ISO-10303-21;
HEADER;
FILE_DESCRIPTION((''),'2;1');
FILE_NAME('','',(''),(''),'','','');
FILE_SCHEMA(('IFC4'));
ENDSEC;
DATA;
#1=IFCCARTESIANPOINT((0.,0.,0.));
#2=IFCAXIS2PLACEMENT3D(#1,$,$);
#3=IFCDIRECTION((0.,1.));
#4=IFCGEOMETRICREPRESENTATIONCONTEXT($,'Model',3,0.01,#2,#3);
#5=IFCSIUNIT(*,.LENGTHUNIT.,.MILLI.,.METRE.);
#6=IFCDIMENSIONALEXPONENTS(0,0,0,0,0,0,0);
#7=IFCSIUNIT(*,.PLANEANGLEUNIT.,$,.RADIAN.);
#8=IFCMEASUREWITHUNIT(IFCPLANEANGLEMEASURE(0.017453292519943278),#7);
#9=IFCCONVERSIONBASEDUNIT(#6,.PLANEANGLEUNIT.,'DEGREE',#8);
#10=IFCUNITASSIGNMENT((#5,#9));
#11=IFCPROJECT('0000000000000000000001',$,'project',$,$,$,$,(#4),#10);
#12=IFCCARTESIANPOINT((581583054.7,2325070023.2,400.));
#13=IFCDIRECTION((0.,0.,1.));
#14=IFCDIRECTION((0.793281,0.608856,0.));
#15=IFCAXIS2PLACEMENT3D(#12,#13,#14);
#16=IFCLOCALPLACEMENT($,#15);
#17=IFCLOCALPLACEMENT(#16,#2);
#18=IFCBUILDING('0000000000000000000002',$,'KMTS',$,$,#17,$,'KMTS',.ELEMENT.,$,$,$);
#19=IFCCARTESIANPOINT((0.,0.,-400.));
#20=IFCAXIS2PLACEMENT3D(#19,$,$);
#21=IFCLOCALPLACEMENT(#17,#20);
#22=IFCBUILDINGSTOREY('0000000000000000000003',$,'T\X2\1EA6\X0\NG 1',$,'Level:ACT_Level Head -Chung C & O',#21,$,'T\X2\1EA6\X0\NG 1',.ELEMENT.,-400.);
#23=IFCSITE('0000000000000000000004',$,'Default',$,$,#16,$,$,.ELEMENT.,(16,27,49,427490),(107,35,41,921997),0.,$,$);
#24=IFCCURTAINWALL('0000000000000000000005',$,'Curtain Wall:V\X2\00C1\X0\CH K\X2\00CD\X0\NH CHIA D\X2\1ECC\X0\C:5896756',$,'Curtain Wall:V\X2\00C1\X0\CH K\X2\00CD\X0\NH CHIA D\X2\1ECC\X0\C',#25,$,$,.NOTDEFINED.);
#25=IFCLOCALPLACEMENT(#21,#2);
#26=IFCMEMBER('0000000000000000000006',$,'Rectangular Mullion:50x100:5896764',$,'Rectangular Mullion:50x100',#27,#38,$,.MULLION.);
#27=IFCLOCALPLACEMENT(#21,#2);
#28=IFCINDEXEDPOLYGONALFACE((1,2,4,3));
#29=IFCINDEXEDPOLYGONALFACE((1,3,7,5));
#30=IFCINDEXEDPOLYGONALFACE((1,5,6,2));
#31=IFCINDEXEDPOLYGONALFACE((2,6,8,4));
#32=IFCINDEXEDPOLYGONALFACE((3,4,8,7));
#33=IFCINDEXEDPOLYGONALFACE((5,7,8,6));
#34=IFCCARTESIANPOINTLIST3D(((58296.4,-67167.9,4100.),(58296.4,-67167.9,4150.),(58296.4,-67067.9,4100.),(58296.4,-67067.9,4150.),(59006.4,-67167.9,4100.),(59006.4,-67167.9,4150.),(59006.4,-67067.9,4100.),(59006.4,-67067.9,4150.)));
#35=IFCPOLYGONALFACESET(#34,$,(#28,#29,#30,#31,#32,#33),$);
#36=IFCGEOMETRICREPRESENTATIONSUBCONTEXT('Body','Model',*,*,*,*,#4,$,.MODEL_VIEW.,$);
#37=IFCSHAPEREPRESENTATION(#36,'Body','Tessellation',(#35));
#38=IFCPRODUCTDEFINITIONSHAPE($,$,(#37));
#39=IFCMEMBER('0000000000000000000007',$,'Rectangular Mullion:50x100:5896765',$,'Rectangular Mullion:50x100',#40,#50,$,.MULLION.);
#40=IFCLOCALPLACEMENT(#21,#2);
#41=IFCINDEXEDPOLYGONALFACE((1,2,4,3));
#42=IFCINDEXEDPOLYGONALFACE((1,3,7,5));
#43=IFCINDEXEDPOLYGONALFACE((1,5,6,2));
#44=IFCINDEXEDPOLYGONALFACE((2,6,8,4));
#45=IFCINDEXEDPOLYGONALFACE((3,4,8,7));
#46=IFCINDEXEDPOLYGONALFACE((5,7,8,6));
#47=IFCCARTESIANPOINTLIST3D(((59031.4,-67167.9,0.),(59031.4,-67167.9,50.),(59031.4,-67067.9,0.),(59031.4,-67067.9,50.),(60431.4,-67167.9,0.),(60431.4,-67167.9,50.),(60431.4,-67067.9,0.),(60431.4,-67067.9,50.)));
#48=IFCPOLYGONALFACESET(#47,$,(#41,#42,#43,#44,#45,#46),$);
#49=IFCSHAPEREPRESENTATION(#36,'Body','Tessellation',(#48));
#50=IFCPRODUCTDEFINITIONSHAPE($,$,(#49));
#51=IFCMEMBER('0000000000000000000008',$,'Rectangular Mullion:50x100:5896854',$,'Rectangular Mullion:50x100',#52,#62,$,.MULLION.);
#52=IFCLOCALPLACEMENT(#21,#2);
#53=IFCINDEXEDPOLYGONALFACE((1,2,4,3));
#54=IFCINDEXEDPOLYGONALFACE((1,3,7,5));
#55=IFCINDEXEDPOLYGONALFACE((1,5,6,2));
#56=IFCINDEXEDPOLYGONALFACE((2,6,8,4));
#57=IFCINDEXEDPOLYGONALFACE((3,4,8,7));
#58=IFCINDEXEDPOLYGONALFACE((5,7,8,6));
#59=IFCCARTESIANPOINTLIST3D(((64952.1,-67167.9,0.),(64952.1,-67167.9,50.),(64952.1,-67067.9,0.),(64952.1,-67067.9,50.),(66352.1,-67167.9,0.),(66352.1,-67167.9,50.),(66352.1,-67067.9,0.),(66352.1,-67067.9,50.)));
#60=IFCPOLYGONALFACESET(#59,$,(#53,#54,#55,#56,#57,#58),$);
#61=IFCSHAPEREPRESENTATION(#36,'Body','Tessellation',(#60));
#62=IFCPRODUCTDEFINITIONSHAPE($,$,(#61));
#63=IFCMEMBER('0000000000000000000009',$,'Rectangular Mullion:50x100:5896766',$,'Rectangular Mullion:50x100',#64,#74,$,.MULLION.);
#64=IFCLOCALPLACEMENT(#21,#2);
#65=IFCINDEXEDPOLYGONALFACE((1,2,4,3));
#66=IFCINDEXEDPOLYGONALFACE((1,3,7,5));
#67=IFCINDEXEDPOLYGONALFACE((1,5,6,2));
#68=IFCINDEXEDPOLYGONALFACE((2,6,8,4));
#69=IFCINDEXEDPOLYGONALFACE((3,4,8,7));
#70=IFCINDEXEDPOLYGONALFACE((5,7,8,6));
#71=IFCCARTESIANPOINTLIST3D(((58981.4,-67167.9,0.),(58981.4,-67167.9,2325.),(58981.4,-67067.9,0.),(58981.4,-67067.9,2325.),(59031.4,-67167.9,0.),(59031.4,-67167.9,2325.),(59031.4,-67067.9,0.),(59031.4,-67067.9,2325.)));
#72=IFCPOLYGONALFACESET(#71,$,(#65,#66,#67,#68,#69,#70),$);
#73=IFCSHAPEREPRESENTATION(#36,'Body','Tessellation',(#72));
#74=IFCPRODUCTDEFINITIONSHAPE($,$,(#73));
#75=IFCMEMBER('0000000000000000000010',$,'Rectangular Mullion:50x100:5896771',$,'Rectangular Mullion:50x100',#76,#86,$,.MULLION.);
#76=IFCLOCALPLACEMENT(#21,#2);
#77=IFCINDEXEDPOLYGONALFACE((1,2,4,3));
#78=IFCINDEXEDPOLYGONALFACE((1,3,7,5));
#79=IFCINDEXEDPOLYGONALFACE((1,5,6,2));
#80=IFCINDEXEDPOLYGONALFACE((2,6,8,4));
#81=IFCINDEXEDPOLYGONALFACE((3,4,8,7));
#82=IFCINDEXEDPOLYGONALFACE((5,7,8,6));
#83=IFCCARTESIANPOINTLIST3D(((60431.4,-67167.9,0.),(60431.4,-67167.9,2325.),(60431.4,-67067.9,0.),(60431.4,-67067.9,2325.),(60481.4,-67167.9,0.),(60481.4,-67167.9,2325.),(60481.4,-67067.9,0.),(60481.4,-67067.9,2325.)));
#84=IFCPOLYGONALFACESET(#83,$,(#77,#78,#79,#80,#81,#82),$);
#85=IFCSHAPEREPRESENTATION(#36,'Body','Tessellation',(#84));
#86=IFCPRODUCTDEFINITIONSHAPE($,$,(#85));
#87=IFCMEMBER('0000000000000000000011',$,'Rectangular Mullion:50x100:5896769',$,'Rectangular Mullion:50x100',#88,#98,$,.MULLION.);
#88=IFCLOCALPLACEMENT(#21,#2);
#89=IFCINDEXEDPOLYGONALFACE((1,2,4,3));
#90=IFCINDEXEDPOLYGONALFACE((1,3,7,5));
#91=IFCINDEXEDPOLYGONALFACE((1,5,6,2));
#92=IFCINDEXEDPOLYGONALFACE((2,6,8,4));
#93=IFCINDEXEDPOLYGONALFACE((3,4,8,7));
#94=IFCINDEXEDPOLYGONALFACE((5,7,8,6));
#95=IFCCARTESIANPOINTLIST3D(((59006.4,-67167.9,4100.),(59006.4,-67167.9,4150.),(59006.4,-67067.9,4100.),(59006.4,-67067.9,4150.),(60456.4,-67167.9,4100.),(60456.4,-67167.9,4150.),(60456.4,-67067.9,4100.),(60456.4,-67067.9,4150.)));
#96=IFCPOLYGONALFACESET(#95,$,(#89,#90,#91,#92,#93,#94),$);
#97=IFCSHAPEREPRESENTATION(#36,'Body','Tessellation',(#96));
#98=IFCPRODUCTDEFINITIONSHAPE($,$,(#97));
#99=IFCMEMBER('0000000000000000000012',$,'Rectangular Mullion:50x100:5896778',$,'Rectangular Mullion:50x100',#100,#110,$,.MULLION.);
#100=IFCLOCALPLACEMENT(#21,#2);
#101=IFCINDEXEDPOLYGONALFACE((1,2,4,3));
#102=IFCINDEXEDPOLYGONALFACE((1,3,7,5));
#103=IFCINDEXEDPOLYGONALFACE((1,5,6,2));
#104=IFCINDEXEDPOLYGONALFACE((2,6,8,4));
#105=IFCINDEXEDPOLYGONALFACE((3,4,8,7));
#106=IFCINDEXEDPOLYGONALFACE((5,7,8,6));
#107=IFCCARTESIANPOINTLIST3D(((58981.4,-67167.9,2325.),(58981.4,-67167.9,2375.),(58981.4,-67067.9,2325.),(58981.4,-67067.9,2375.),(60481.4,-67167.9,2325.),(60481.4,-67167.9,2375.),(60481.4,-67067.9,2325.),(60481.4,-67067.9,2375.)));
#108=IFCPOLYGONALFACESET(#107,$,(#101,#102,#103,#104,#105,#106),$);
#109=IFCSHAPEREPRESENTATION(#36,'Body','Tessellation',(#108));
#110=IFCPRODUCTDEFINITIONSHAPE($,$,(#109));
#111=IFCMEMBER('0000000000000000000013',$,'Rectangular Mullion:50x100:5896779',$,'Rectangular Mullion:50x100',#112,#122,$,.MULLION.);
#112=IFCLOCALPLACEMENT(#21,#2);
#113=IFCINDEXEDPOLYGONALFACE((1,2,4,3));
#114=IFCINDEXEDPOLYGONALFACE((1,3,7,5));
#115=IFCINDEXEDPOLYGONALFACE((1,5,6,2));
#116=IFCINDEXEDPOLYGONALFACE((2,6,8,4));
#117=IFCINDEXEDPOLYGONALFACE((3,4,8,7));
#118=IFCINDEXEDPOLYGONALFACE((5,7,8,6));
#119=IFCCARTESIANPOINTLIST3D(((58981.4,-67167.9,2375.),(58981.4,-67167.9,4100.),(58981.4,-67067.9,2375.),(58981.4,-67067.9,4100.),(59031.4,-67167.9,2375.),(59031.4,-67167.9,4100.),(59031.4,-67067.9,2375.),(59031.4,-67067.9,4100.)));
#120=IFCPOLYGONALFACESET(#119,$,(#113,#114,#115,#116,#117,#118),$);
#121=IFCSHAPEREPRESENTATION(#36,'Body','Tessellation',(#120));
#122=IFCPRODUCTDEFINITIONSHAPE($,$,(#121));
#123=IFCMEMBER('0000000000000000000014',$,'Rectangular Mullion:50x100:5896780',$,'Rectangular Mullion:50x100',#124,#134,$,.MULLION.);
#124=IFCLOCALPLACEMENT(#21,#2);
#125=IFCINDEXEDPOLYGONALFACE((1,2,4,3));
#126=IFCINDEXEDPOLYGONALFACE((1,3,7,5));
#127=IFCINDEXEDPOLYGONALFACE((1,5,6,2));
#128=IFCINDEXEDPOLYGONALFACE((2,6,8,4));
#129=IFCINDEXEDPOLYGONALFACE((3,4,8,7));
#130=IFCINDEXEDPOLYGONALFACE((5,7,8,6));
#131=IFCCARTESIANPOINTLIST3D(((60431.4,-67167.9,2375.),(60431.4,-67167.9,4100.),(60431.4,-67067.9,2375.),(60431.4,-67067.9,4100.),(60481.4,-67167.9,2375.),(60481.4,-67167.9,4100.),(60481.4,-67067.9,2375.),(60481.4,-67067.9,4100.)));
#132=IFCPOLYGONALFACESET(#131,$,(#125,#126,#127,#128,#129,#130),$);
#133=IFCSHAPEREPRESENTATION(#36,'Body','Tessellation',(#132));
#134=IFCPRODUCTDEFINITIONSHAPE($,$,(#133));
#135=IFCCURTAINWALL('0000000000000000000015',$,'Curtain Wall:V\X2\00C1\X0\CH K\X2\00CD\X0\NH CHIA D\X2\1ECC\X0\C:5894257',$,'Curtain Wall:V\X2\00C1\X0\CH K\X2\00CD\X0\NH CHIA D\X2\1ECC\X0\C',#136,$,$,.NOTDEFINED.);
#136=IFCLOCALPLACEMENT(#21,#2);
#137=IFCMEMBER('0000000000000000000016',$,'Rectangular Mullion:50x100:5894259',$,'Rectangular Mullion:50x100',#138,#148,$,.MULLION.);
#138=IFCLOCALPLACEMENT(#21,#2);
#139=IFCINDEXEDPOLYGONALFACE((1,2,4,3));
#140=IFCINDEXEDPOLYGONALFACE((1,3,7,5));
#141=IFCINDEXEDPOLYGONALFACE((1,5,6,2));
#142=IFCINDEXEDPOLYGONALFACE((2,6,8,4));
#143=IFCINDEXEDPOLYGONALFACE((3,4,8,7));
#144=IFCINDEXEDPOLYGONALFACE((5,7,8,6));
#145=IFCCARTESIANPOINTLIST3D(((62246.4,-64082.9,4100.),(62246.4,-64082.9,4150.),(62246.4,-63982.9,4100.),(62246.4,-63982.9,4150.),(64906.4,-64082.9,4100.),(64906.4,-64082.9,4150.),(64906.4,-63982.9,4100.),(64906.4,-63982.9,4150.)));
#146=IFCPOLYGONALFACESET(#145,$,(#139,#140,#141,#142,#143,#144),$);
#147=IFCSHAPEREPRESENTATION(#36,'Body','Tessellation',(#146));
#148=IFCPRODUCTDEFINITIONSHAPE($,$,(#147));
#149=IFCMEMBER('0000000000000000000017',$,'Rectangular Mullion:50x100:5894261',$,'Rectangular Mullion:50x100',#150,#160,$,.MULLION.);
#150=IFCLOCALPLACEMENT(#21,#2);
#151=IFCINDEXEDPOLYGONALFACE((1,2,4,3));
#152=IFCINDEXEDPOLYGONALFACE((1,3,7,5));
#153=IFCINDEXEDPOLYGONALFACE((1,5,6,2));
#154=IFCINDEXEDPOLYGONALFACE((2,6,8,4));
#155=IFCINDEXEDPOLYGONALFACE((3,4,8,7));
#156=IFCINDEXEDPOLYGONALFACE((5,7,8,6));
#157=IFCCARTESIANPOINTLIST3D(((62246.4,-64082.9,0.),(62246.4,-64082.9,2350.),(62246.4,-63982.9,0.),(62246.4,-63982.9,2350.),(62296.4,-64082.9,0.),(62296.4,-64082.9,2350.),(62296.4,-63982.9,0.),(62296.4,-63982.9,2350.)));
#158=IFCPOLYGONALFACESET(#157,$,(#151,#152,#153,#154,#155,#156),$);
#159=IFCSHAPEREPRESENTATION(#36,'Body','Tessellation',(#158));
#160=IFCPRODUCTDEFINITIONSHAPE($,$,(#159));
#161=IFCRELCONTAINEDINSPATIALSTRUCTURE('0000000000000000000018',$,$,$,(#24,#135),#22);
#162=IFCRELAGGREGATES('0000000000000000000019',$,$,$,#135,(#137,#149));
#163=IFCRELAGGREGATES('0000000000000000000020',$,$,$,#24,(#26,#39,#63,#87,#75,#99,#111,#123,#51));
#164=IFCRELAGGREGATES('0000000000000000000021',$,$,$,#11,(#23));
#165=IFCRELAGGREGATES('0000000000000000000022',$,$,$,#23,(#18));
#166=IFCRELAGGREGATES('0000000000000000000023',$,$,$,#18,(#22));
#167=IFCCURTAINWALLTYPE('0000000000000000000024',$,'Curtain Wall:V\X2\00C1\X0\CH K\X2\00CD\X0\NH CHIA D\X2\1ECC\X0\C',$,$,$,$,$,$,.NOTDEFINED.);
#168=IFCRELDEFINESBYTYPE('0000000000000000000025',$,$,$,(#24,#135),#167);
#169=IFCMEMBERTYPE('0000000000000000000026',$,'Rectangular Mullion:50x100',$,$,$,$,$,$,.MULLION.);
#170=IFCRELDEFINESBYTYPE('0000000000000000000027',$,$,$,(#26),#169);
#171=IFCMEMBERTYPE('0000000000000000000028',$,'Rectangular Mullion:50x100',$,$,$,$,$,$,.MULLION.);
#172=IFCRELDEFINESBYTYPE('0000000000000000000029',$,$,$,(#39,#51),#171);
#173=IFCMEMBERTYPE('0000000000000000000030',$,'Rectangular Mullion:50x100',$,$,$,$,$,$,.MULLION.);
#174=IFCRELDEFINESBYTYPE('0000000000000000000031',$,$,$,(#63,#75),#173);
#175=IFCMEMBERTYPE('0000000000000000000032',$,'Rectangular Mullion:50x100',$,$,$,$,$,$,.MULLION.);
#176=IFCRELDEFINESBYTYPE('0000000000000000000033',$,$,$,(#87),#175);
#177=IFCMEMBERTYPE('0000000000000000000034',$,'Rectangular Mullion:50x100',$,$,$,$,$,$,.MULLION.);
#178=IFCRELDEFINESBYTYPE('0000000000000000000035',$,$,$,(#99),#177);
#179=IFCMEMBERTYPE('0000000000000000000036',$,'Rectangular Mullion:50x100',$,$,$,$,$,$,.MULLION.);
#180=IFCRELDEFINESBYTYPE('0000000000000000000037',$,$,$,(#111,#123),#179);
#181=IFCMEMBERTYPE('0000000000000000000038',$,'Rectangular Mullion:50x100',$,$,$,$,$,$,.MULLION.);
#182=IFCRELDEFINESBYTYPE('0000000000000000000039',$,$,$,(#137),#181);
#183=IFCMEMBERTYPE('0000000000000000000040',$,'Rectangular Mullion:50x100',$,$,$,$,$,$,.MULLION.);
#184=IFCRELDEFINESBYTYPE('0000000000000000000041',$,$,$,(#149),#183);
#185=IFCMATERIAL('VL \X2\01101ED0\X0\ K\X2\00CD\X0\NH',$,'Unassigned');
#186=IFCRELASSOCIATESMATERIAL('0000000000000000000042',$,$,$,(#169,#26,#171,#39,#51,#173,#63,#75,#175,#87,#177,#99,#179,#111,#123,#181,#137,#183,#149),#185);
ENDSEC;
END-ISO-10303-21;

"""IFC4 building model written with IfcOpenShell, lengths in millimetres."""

from ifc_helpers import new_model, entity, si_unit, converted_unit, direction, frame, origin, place, context, subcontext, project, spatial, indexed_curve, outline, extrude, source, transform, mapped, material, type_object, type_shapes, element, aggregate, save


model = new_model("IFC4")

# Units and contexts
model_context = context("Model", 3, precision=0.01, world=origin(), true_north=direction((0.0, 1.0)))
body_context = subcontext(model_context, "Body", "Model", "MODEL_VIEW")
ifc_project = project(units=[si_unit("LENGTHUNIT", "METRE", prefix="MILLI"), converted_unit("PLANEANGLEUNIT", "DEGREE", entity("IfcPlaneAngleMeasure", 0.017453292519943278), si_unit("PLANEANGLEUNIT", "RADIAN"), dimensions=[0, 0, 0, 0, 0, 0, 0])], contexts=[model_context])

# Site, building, storey
site_placement = place(None, frame((581583054.7, 2325070023.2, 400.0), z_axis=(0.0, 0.0, 1.0), x_axis=(0.793281, 0.608856, 0.0)))
site = spatial("IfcSite", under=ifc_project, at=site_placement, Name="Default", CompositionType="ELEMENT", RefLatitude=(16, 27, 49, 427490), RefLongitude=(107, 35, 41, 921997), RefElevation=0.0)
building_placement = place(site_placement, origin())
building = spatial("IfcBuilding", under=site, at=building_placement, Name="KMTS", LongName="KMTS", CompositionType="ELEMENT")
storey_placement = place(building_placement, frame((0.0, 0.0, -400.0)))
storey = spatial("IfcBuildingStorey", under=building, at=storey_placement, Name="TẦNG 1", ObjectType="Level:ACT_Level Head -Chung C & O", LongName="TẦNG 1", CompositionType="ELEMENT", Elevation=-400.0)

# Curtain walls, members
curtain_wall_type = type_object("IfcCurtainWallType", Name="Curtain Wall:VÁCH KÍNH CHIA DỌC", PredefinedType="NOTDEFINED")
curtain_wall_1_placement = place(storey_placement, frame((0.0, 0.0, 400.0)))
curtain_wall_1 = element("IfcCurtainWall", 1, at=curtain_wall_1_placement, inside=storey, type_object=curtain_wall_type, Name="Curtain Wall:VÁCH KÍNH CHIA DỌC:5896756", ObjectType="Curtain Wall:VÁCH KÍNH CHIA DỌC", PredefinedType="NOTDEFINED")
ifc_material_1 = material(Name="VL ĐỐ KÍNH", Category="Unassigned")
member_type_1 = type_object("IfcMemberType", Name="Rectangular Mullion:50x100", PredefinedType="MULLION", material=ifc_material_1)
shared_shape_1 = source(origin(), body_context, "Body", "SweptSolid", [
    extrude(outline(indexed_curve([(-25.0, -50.0), (25.0, -50.0), (25.0, 50.0), (-25.0, 50.0), (-25.0, -50.0)], self_intersect=False)), frame((-25.0, 0.0, -710.0), z_axis=(0.0, 0.0, 1.0), x_axis=(-1.0, 0.0, 0.0)), (0.0, 0.0, 1.0), 710.0),
])
type_shapes(member_type_1, [shared_shape_1])
member_1_placement = place(curtain_wall_1_placement, frame((59006.4, -67117.9, 3750.0), z_axis=(1.0, 0.0, 0.0), x_axis=(0.0, 0.0, 1.0)))
member_1 = element("IfcMember", 2, at=member_1_placement, type_object=member_type_1, material=ifc_material_1, Name="Rectangular Mullion:50x100:5896764", ObjectType="Rectangular Mullion:50x100", PredefinedType="MULLION", context=body_context, shape_type="MappedRepresentation", body=[
    mapped(shared_shape_1, transform((0.0, 0.0, 0.0), scale=1.0)),
])
member_type_2 = type_object("IfcMemberType", Name="Rectangular Mullion:50x100", PredefinedType="MULLION", material=ifc_material_1)
shared_shape_2 = source(origin(), body_context, "Body", "SweptSolid", [
    extrude(outline(indexed_curve([(-25.0, -50.0), (25.0, -50.0), (25.0, 50.0), (-25.0, 50.0), (-25.0, -50.0)], self_intersect=False)), frame((-25.0, 0.0, -1400.0), z_axis=(0.0, 0.0, 1.0), x_axis=(-1.0, 0.0, 0.0)), (0.0, 0.0, 1.0), 1400.0),
])
type_shapes(member_type_2, [shared_shape_2])
member_2_placement = place(curtain_wall_1_placement, frame((59031.4, -67117.9, -400.0), z_axis=(-1.0, 0.0, 0.0), x_axis=(0.0, 0.0, -1.0)))
member_2 = element("IfcMember", 3, at=member_2_placement, type_object=member_type_2, material=ifc_material_1, Name="Rectangular Mullion:50x100:5896765", ObjectType="Rectangular Mullion:50x100", PredefinedType="MULLION", context=body_context, shape_type="MappedRepresentation", body=[
    mapped(shared_shape_2, transform((0.0, 0.0, 0.0), scale=1.0)),
])
member_3_placement = place(curtain_wall_1_placement, frame((64952.1, -67117.9, -400.0), z_axis=(-1.0, 0.0, 0.0), x_axis=(0.0, 0.0, -1.0)))
member_3 = element("IfcMember", 4, at=member_3_placement, type_object=member_type_2, material=ifc_material_1, Name="Rectangular Mullion:50x100:5896854", ObjectType="Rectangular Mullion:50x100", PredefinedType="MULLION", context=body_context, shape_type="MappedRepresentation", body=[
    mapped(shared_shape_2, transform((0.0, 0.0, 0.0), scale=1.0)),
])
member_type_3 = type_object("IfcMemberType", Name="Rectangular Mullion:50x100", PredefinedType="MULLION", material=ifc_material_1)
shared_shape_3 = source(origin(), body_context, "Body", "SweptSolid", [
    extrude(outline(indexed_curve([(-25.0, -50.0), (25.0, -50.0), (25.0, 50.0), (-25.0, 50.0), (-25.0, -50.0)], self_intersect=False)), frame((0.0, 0.0, -2325.0), z_axis=(0.0, 0.0, 1.0), x_axis=(-1.0, 0.0, 0.0)), (0.0, 0.0, 1.0), 2325.0),
])
type_shapes(member_type_3, [shared_shape_3])
member_4_placement = place(curtain_wall_1_placement, frame((59006.4, -67117.9, -400.0), z_axis=(0.0, 0.0, -1.0), x_axis=(1.0, 0.0, 0.0)))
member_4 = element("IfcMember", 5, at=member_4_placement, type_object=member_type_3, material=ifc_material_1, Name="Rectangular Mullion:50x100:5896766", ObjectType="Rectangular Mullion:50x100", PredefinedType="MULLION", context=body_context, shape_type="MappedRepresentation", body=[
    mapped(shared_shape_3, transform((0.0, 0.0, 0.0), scale=1.0)),
])
member_5_placement = place(curtain_wall_1_placement, frame((60456.4, -67117.9, -400.0), z_axis=(0.0, 0.0, -1.0), x_axis=(1.0, 0.0, 0.0)))
member_5 = element("IfcMember", 6, at=member_5_placement, type_object=member_type_3, material=ifc_material_1, Name="Rectangular Mullion:50x100:5896771", ObjectType="Rectangular Mullion:50x100", PredefinedType="MULLION", context=body_context, shape_type="MappedRepresentation", body=[
    mapped(shared_shape_3, transform((0.0, 0.0, 0.0), scale=1.0)),
])
member_type_4 = type_object("IfcMemberType", Name="Rectangular Mullion:50x100", PredefinedType="MULLION", material=ifc_material_1)
shared_shape_4 = source(origin(), body_context, "Body", "SweptSolid", [
    extrude(outline(indexed_curve([(-25.0, -50.0), (25.0, -50.0), (25.0, 50.0), (-25.0, 50.0), (-25.0, -50.0)], self_intersect=False)), frame((-25.0, 0.0, -1450.0), z_axis=(0.0, 0.0, 1.0), x_axis=(-1.0, 0.0, 0.0)), (0.0, 0.0, 1.0), 1450.0),
])
type_shapes(member_type_4, [shared_shape_4])
member_6_placement = place(curtain_wall_1_placement, frame((60456.4, -67117.9, 3750.0), z_axis=(1.0, 0.0, 0.0), x_axis=(0.0, 0.0, 1.0)))
member_6 = element("IfcMember", 7, at=member_6_placement, type_object=member_type_4, material=ifc_material_1, Name="Rectangular Mullion:50x100:5896769", ObjectType="Rectangular Mullion:50x100", PredefinedType="MULLION", context=body_context, shape_type="MappedRepresentation", body=[
    mapped(shared_shape_4, transform((0.0, 0.0, 0.0), scale=1.0)),
])
member_type_5 = type_object("IfcMemberType", Name="Rectangular Mullion:50x100", PredefinedType="MULLION", material=ifc_material_1)
shared_shape_5 = source(origin(), body_context, "Body", "SweptSolid", [
    extrude(outline(indexed_curve([(-25.0, -50.0), (25.0, -50.0), (25.0, 50.0), (-25.0, 50.0), (-25.0, -50.0)], self_intersect=False)), frame((0.0, 0.0, -1500.0), z_axis=(0.0, 0.0, 1.0), x_axis=(-1.0, 0.0, 0.0)), (0.0, 0.0, 1.0), 1500.0),
])
type_shapes(member_type_5, [shared_shape_5])
member_7_placement = place(curtain_wall_1_placement, frame((60481.4, -67117.9, 1950.0), z_axis=(1.0, 0.0, 0.0), x_axis=(0.0, 0.0, 1.0)))
member_7 = element("IfcMember", 8, at=member_7_placement, type_object=member_type_5, material=ifc_material_1, Name="Rectangular Mullion:50x100:5896778", ObjectType="Rectangular Mullion:50x100", PredefinedType="MULLION", context=body_context, shape_type="MappedRepresentation", body=[
    mapped(shared_shape_5, transform((0.0, 0.0, 0.0), scale=1.0)),
])
member_type_6 = type_object("IfcMemberType", Name="Rectangular Mullion:50x100", PredefinedType="MULLION", material=ifc_material_1)
shared_shape_6 = source(origin(), body_context, "Body", "SweptSolid", [
    extrude(outline(indexed_curve([(-25.0, -50.0), (25.0, -50.0), (25.0, 50.0), (-25.0, 50.0), (-25.0, -50.0)], self_intersect=False)), frame((0.0, 0.0, -1725.0), z_axis=(0.0, 0.0, 1.0), x_axis=(-1.0, 0.0, 0.0)), (0.0, 0.0, 1.0), 1725.0),
])
type_shapes(member_type_6, [shared_shape_6])
member_8_placement = place(curtain_wall_1_placement, frame((59006.4, -67117.9, 1975.0), z_axis=(0.0, 0.0, -1.0), x_axis=(1.0, 0.0, 0.0)))
member_8 = element("IfcMember", 9, at=member_8_placement, type_object=member_type_6, material=ifc_material_1, Name="Rectangular Mullion:50x100:5896779", ObjectType="Rectangular Mullion:50x100", PredefinedType="MULLION", context=body_context, shape_type="MappedRepresentation", body=[
    mapped(shared_shape_6, transform((0.0, 0.0, 0.0), scale=1.0)),
])
member_9_placement = place(curtain_wall_1_placement, frame((60456.4, -67117.9, 1975.0), z_axis=(0.0, 0.0, -1.0), x_axis=(1.0, 0.0, 0.0)))
member_9 = element("IfcMember", 10, at=member_9_placement, type_object=member_type_6, material=ifc_material_1, Name="Rectangular Mullion:50x100:5896780", ObjectType="Rectangular Mullion:50x100", PredefinedType="MULLION", context=body_context, shape_type="MappedRepresentation", body=[
    mapped(shared_shape_6, transform((0.0, 0.0, 0.0), scale=1.0)),
])
curtain_wall_2_placement = place(storey_placement, frame((0.0, 0.0, 400.0)))
curtain_wall_2 = element("IfcCurtainWall", 11, at=curtain_wall_2_placement, inside=storey, type_object=curtain_wall_type, Name="Curtain Wall:VÁCH KÍNH CHIA DỌC:5894257", ObjectType="Curtain Wall:VÁCH KÍNH CHIA DỌC", PredefinedType="NOTDEFINED")
member_type_7 = type_object("IfcMemberType", Name="Rectangular Mullion:50x100", PredefinedType="MULLION", material=ifc_material_1)
shared_shape_7 = source(origin(), body_context, "Body", "SweptSolid", [
    extrude(outline(indexed_curve([(-25.0, -50.0), (25.0, -50.0), (25.0, 50.0), (-25.0, 50.0), (-25.0, -50.0)], self_intersect=False)), frame((-25.0, 0.0, -2660.0), z_axis=(0.0, 0.0, 1.0), x_axis=(-1.0, 0.0, 0.0)), (0.0, 0.0, 1.0), 2660.0),
])
type_shapes(member_type_7, [shared_shape_7])
member_10_placement = place(curtain_wall_2_placement, frame((62246.4, -64032.9, 3750.0), z_axis=(-1.0, 0.0, 0.0), x_axis=(0.0, 0.0, 1.0)))
member_10 = element("IfcMember", 12, at=member_10_placement, type_object=member_type_7, material=ifc_material_1, Name="Rectangular Mullion:50x100:5894259", ObjectType="Rectangular Mullion:50x100", PredefinedType="MULLION", context=body_context, shape_type="MappedRepresentation", body=[
    mapped(shared_shape_7, transform((0.0, 0.0, 0.0), scale=1.0)),
])
member_type_8 = type_object("IfcMemberType", Name="Rectangular Mullion:50x100", PredefinedType="MULLION", material=ifc_material_1)
shared_shape_8 = source(origin(), body_context, "Body", "SweptSolid", [
    extrude(outline(indexed_curve([(-25.0, -50.0), (25.0, -50.0), (25.0, 50.0), (-25.0, 50.0), (-25.0, -50.0)], self_intersect=False)), frame((-25.0, 0.0, -2350.0), z_axis=(0.0, 0.0, 1.0), x_axis=(-1.0, 0.0, 0.0)), (0.0, 0.0, 1.0), 2350.0),
])
type_shapes(member_type_8, [shared_shape_8])
member_11_placement = place(curtain_wall_2_placement, frame((62246.4, -64032.9, -400.0), z_axis=(0.0, 0.0, -1.0), x_axis=(-1.0, 0.0, 0.0)))
member_11 = element("IfcMember", 13, at=member_11_placement, type_object=member_type_8, material=ifc_material_1, Name="Rectangular Mullion:50x100:5894261", ObjectType="Rectangular Mullion:50x100", PredefinedType="MULLION", context=body_context, shape_type="MappedRepresentation", body=[
    mapped(shared_shape_8, transform((0.0, 0.0, 0.0), scale=1.0)),
])

aggregate(curtain_wall_2, [member_10, member_11])

aggregate(curtain_wall_1, [member_1, member_2, member_4, member_6, member_5, member_7, member_8, member_9, member_3])

save(model, "model.ifc")
